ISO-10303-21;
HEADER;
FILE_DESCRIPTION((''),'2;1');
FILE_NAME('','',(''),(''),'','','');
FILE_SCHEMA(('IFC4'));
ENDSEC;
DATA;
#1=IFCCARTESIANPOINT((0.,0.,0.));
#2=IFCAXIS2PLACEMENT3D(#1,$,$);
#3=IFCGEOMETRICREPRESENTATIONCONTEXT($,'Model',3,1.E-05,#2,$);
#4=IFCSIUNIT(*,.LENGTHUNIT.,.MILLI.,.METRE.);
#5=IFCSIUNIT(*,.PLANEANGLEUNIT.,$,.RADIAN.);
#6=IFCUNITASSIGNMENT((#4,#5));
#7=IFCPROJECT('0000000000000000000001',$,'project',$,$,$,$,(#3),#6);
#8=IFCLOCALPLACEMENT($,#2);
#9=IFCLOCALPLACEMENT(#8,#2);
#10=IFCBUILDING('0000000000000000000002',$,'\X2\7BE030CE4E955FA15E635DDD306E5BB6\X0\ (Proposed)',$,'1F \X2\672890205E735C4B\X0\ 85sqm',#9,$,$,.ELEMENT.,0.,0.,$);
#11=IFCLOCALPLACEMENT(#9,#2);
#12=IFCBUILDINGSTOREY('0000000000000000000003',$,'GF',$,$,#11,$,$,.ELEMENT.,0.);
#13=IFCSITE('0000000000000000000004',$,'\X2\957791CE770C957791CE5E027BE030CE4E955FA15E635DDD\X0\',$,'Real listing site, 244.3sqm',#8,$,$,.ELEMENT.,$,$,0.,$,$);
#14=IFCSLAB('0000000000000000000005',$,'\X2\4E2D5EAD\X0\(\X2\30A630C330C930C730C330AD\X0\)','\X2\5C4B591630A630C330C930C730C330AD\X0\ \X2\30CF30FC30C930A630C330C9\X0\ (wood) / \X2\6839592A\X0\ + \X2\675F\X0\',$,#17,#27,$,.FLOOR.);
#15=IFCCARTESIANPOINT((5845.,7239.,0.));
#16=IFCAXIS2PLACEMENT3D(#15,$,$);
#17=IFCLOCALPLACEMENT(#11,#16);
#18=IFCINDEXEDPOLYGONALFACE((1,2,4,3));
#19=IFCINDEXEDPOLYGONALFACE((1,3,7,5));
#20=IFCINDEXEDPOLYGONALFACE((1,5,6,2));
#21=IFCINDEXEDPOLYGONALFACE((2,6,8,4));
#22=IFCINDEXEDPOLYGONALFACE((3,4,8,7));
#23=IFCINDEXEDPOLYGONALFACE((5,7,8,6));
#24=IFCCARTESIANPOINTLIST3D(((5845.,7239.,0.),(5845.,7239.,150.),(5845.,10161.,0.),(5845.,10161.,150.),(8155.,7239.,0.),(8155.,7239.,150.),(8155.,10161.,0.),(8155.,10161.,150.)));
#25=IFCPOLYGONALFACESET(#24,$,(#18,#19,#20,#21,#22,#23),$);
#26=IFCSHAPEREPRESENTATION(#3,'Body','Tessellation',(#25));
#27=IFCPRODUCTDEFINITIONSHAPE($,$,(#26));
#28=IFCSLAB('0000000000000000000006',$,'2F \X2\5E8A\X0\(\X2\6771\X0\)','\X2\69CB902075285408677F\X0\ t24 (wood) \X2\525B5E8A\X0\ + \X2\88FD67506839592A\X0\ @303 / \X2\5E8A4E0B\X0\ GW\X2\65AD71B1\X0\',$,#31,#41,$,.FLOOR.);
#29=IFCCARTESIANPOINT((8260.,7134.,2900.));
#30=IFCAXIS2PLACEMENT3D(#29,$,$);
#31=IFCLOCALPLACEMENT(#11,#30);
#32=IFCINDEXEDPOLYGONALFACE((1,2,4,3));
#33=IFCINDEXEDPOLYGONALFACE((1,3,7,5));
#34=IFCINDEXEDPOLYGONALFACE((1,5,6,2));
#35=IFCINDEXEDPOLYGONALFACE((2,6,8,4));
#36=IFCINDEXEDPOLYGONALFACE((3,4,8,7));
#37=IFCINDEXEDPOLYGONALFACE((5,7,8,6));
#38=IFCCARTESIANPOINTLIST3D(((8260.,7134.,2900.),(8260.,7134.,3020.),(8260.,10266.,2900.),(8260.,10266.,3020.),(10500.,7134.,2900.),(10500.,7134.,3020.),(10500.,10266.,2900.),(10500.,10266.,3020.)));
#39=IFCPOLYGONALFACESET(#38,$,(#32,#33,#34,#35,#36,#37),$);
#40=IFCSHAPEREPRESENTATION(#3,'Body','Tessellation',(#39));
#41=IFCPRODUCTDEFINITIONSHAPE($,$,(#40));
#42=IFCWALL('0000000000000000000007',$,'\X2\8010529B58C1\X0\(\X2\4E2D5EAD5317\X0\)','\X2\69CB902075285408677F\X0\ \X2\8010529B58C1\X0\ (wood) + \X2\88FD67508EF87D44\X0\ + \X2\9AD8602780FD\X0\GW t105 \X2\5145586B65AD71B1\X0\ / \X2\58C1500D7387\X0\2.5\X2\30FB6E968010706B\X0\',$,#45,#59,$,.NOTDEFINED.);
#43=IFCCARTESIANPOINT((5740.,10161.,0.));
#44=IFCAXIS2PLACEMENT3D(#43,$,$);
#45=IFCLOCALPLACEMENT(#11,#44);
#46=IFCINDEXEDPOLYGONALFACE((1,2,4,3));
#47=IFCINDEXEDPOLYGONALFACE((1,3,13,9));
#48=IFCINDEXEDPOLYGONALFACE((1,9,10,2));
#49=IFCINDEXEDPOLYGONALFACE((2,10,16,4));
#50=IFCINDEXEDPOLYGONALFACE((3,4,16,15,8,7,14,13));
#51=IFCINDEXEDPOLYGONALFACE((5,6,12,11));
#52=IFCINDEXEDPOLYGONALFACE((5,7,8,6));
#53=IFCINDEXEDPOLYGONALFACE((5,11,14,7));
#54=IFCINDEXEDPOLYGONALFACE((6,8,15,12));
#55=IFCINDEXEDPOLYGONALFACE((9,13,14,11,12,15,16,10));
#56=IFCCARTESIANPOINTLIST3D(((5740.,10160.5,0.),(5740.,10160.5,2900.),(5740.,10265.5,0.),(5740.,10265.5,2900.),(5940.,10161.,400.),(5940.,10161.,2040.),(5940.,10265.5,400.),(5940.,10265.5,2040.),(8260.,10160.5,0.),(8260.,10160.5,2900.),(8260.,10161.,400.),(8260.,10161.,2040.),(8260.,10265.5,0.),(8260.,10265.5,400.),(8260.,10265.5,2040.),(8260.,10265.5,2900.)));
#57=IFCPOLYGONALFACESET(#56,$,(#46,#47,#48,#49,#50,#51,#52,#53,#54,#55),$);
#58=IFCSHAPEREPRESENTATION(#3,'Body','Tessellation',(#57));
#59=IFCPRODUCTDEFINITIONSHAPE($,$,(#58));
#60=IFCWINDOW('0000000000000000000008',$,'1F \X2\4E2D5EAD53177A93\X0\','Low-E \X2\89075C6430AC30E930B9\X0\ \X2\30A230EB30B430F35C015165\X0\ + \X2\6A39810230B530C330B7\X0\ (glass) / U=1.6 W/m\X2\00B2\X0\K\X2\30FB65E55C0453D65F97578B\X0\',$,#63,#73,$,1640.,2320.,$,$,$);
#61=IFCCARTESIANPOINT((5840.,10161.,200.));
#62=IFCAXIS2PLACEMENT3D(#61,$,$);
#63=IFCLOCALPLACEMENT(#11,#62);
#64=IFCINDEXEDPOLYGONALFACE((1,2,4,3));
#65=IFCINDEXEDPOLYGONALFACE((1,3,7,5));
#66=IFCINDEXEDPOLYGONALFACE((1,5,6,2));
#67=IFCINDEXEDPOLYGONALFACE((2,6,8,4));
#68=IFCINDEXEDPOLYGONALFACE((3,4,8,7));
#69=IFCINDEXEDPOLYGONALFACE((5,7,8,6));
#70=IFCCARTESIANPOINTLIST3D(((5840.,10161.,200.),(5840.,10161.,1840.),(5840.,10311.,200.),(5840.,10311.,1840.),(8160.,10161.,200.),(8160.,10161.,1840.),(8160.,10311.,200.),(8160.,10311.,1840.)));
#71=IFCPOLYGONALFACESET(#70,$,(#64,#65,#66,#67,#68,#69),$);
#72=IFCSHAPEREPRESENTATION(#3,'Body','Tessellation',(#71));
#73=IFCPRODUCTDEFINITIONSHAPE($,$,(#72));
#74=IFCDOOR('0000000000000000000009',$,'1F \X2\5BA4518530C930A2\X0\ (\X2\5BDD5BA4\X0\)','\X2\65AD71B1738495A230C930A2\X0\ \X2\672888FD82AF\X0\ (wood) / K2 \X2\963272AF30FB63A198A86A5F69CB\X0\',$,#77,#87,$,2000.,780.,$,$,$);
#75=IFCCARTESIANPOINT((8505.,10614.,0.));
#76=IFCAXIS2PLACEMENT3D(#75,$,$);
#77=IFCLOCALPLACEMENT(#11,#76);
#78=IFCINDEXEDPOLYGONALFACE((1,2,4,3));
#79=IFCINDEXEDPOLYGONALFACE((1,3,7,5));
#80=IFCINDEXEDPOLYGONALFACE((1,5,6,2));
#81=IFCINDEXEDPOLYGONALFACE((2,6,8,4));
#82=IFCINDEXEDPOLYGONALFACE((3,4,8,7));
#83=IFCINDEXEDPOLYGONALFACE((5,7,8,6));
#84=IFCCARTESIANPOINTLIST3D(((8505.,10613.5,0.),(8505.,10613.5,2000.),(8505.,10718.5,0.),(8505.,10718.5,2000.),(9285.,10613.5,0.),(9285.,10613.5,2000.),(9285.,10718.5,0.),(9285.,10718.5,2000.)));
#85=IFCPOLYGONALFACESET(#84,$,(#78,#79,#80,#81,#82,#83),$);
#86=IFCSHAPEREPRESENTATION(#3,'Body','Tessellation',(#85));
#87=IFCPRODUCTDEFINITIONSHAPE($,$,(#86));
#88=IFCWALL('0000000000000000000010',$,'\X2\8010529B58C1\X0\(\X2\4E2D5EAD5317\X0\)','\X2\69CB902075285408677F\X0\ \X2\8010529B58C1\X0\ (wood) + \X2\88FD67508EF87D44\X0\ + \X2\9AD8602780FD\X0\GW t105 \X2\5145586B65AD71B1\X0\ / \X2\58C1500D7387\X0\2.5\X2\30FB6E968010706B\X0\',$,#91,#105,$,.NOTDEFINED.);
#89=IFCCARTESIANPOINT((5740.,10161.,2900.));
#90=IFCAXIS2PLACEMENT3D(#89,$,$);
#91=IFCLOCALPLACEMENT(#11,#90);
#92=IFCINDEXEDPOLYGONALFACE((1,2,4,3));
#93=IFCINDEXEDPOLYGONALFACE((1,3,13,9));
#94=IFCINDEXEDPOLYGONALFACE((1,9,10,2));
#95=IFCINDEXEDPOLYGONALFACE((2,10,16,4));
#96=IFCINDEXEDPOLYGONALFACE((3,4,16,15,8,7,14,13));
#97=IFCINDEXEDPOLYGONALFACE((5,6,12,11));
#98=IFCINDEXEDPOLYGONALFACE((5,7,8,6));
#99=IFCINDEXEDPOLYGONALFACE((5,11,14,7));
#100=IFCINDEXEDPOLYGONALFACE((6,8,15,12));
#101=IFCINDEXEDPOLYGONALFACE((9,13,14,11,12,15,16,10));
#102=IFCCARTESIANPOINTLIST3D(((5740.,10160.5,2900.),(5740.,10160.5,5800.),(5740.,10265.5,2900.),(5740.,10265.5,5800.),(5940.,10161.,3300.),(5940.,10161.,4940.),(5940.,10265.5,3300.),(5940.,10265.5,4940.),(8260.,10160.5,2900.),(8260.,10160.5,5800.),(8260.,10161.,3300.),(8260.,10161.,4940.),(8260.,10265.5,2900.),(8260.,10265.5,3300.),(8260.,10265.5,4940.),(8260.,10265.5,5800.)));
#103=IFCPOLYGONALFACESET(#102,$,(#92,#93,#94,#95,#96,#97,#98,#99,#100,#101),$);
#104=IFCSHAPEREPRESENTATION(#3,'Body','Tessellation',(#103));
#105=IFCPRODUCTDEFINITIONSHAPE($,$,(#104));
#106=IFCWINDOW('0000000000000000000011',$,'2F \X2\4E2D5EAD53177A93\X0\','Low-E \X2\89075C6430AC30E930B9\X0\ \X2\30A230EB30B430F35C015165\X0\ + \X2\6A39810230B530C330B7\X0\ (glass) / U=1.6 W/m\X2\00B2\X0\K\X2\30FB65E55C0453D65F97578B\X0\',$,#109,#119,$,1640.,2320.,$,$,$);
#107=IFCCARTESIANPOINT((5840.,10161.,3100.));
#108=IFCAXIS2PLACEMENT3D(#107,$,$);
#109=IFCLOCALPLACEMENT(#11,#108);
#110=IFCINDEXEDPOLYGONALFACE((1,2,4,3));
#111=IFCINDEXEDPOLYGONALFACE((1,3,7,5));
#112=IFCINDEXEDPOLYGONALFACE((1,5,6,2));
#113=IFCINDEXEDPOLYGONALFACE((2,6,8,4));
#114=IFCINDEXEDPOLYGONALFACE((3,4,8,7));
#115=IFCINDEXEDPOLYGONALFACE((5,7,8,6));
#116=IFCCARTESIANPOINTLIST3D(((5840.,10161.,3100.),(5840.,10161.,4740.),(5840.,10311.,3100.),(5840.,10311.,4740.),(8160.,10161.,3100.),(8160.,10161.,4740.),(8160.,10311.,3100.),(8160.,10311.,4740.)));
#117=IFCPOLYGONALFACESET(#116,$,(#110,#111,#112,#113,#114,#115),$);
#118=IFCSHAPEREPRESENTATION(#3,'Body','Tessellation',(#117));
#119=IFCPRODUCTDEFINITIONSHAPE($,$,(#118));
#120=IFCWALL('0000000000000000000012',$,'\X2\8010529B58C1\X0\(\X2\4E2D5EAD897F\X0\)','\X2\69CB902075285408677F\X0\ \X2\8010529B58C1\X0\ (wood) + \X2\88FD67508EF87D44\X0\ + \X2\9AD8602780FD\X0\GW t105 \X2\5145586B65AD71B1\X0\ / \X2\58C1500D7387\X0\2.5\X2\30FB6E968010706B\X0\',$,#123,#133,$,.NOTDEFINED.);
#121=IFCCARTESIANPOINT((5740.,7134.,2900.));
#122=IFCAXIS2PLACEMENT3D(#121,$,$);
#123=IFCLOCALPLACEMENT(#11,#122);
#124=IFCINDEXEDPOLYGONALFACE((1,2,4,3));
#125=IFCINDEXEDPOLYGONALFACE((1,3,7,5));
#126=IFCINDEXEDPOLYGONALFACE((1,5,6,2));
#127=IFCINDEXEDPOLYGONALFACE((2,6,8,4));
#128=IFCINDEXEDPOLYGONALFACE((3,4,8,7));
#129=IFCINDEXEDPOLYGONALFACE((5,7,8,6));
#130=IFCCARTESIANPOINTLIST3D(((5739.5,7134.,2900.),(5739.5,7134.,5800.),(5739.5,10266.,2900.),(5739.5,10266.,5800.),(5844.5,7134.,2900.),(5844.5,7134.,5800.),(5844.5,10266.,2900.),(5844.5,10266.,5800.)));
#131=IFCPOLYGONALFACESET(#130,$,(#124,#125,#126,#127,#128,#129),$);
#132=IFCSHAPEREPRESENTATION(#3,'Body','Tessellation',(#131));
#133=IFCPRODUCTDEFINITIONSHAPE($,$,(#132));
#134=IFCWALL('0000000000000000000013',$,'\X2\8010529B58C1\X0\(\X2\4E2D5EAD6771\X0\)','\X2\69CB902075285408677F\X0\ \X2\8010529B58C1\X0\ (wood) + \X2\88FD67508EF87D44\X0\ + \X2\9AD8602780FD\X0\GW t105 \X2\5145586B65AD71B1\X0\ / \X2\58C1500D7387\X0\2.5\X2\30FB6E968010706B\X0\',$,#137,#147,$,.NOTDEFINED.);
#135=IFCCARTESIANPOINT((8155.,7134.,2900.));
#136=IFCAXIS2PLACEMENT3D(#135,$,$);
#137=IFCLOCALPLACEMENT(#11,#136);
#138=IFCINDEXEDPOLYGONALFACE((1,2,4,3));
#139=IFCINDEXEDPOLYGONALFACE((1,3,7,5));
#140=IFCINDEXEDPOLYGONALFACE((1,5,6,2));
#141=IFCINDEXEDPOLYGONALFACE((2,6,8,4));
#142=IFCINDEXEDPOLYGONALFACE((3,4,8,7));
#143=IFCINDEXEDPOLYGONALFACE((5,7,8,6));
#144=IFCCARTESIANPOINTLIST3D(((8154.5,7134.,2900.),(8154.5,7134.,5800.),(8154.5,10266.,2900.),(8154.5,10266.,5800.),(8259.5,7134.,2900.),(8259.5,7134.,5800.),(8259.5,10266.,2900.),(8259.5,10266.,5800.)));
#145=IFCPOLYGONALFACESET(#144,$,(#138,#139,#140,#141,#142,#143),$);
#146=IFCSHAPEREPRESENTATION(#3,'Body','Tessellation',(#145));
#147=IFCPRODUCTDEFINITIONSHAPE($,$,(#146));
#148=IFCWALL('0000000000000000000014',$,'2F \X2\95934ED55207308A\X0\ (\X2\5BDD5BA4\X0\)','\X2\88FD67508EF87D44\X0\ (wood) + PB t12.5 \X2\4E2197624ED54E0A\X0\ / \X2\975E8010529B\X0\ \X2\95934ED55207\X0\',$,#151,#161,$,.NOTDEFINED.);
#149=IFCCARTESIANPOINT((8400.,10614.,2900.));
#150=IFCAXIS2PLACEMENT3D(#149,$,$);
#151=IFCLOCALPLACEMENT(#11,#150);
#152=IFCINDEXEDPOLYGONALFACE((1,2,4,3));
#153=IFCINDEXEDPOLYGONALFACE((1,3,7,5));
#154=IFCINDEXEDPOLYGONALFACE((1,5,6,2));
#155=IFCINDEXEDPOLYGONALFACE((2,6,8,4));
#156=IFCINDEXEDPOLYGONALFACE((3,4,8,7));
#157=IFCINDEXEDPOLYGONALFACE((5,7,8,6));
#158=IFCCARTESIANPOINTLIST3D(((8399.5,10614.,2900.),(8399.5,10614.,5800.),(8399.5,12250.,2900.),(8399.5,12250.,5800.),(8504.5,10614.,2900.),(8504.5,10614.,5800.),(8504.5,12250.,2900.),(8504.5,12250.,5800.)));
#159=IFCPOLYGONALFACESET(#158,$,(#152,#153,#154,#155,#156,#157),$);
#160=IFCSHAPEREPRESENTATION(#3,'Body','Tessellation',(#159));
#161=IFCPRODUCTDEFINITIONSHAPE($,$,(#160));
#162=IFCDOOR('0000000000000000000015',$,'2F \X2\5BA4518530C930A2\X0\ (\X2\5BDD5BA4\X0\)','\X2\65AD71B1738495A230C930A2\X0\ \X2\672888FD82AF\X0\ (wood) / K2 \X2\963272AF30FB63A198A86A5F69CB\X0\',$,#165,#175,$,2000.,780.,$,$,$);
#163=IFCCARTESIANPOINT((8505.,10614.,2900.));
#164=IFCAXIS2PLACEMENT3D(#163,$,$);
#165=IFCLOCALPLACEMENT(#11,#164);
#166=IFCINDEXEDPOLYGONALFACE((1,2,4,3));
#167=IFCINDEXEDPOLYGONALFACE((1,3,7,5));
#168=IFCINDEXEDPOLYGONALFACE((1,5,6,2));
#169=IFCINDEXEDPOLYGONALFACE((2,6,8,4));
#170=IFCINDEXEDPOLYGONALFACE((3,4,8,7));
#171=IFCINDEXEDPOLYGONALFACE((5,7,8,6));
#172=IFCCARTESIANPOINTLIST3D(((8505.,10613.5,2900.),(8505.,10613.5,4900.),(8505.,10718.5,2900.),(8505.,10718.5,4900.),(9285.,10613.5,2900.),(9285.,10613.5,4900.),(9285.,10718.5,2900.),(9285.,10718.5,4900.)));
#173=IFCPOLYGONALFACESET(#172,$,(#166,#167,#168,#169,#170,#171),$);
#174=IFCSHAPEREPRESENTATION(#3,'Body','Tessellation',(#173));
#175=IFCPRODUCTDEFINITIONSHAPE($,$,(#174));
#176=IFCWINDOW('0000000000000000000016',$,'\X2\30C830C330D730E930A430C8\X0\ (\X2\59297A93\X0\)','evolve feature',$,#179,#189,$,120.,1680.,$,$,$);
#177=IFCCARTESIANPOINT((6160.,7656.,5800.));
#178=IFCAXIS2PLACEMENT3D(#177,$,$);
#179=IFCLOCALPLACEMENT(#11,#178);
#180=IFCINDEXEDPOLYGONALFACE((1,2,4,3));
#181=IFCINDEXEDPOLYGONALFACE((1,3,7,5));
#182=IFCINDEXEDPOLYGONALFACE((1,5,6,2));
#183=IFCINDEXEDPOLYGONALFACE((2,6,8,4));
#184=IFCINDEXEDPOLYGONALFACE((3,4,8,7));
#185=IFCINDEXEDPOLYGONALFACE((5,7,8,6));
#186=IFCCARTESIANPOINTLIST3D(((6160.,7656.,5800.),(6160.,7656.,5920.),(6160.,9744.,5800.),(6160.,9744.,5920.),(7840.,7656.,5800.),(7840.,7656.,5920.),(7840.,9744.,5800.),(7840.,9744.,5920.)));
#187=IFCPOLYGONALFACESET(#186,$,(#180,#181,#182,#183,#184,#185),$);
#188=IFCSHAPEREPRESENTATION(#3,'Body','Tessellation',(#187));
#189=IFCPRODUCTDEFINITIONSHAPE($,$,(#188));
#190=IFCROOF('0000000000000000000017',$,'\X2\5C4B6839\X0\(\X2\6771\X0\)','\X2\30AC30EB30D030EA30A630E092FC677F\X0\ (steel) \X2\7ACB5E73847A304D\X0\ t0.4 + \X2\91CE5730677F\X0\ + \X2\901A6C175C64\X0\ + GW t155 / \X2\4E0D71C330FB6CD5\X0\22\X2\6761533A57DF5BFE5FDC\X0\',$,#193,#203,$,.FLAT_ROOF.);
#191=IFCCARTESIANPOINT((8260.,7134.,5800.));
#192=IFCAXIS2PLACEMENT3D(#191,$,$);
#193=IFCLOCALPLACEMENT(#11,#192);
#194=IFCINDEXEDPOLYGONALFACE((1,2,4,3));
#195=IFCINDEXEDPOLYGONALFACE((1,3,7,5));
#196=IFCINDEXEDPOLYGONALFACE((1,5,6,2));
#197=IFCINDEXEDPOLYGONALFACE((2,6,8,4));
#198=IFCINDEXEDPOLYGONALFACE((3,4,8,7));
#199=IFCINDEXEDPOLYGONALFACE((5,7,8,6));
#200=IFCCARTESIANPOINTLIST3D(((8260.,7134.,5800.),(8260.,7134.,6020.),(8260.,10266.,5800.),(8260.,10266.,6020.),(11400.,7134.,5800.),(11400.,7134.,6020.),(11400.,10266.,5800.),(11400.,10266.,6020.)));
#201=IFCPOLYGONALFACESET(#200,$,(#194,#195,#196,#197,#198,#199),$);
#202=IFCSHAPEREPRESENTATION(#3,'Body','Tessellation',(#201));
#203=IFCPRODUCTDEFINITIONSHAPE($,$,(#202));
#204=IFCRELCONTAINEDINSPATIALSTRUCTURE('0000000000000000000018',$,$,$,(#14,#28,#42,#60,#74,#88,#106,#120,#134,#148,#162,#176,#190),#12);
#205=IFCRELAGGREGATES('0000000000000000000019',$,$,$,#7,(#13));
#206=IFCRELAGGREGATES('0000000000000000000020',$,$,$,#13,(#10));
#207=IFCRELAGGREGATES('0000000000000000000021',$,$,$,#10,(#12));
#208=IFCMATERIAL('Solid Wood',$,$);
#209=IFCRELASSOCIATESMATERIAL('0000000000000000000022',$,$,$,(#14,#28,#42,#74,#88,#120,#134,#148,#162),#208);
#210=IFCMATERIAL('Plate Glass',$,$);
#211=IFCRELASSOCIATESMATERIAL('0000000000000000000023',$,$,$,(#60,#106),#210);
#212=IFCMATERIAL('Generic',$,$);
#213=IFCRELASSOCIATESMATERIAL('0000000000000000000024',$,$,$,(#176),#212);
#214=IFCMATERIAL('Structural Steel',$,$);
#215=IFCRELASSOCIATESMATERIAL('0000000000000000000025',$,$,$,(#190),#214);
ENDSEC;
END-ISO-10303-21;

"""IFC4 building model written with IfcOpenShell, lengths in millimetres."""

from ifc_helpers import new_model, si_unit, frame, frame_2d, origin, place, context, project, spatial, rectangle, extrude, material, element, fill, save


model = new_model("IFC4")

# Units and contexts
model_context = context("Model", 3, precision=1e-05, world=origin())
ifc_project = project(units=[si_unit("LENGTHUNIT", "METRE", prefix="MILLI"), si_unit("PLANEANGLEUNIT", "RADIAN")], contexts=[model_context])

# Site, building, storey
site_placement = place(None, origin())
site = spatial("IfcSite", under=ifc_project, at=site_placement, Name="長野県長野市篠ノ井御幣川", ObjectType="Real listing site, 244.3sqm", CompositionType="ELEMENT", RefElevation=0.0)
building_placement = place(site_placement, origin())
building = spatial("IfcBuilding", under=site, at=building_placement, Name="篠ノ井御幣川の家 (Proposed)", ObjectType="1F 木造平屋 85sqm", CompositionType="ELEMENT", ElevationOfRefHeight=0.0, ElevationOfTerrain=0.0)
storey_placement = place(building_placement, origin())
storey = spatial("IfcBuildingStorey", under=building, at=storey_placement, Name="GF", CompositionType="ELEMENT", Elevation=0.0)

# Slabs
ifc_material_1 = material(Name="Solid Wood")
slab_1_placement = place(storey_placement, frame((5845.0, 7239.0, 0.0)))
element("IfcSlab", 1, at=slab_1_placement, inside=storey, material=ifc_material_1, Name="中庭(ウッドデッキ)", Description="屋外ウッドデッキ ハードウッド (wood) / 根太 + 束", PredefinedType="FLOOR", context=model_context, shape_type="SweptSolid", body=[
    extrude(rectangle(XDim=2310.0, YDim=2922.0, at=frame_2d((1155.0, 1461.0))), frame((5845.0, 7239.0, 0.0)), (0.0, 0.0, 1.0), 150.0),
])
slab_2_placement = place(storey_placement, frame((8260.0, 7134.0, 2900.0)))
element("IfcSlab", 2, at=slab_2_placement, inside=storey, material=ifc_material_1, Name="2F 床(東)", Description="構造用合板 t24 (wood) 剛床 + 製材根太 @303 / 床下 GW断熱", PredefinedType="FLOOR", context=model_context, shape_type="SweptSolid", body=[
    extrude(rectangle(XDim=2240.0, YDim=3132.0, at=frame_2d((1120.0, 1566.0))), frame((8260.0, 7134.0, 2900.0)), (0.0, 0.0, 1.0), 120.0),
])

# Wall, opening, window
wall_1_placement = place(storey_placement, frame((5740.0, 10161.0, 0.0)))
wall_1 = element("IfcWall", 3, at=wall_1_placement, inside=storey, material=ifc_material_1, Name="耐力壁(中庭北)", Description="構造用合板 耐力壁 (wood) + 製材軸組 + 高性能GW t105 充填断熱 / 壁倍率2.5・準耐火", PredefinedType="NOTDEFINED", context=model_context, shape_type="SweptSolid", body=[
    extrude(rectangle(XDim=2520.0, YDim=105.0, at=frame_2d((1260.0, 52.0))), frame((5740.0, 10161.0, 0.0)), (0.0, 0.0, 1.0), 2900.0),
])
opening_1_placement = place(storey_placement, frame((5840.0, 10161.0, 200.0)))
opening_1 = element("IfcOpeningElement", 4, at=opening_1_placement, cuts=wall_1, PredefinedType="NOTDEFINED", context=model_context, shape_type="SweptSolid", body=[
    extrude(rectangle(XDim=2320.0, YDim=150.0, at=frame_2d((1160.0, 75.0))), frame((5840.0, 10161.0, 200.0)), (0.0, 0.0, 1.0), 1640.0),
])
ifc_material_2 = material(Name="Plate Glass")
window_1_placement = place(storey_placement, frame((5840.0, 10161.0, 200.0)))
window_1 = element("IfcWindow", 5, at=window_1_placement, inside=storey, material=ifc_material_2, Name="1F 中庭北窓", Description="Low-E 複層ガラス アルゴン封入 + 樹脂サッシ (glass) / U=1.6 W/m²K・日射取得型", OverallHeight=1640.0, OverallWidth=2320.0, context=model_context, shape_type="SweptSolid", body=[
    extrude(rectangle(XDim=2320.0, YDim=150.0, at=frame_2d((1160.0, 75.0))), frame((5840.0, 10161.0, 200.0)), (0.0, 0.0, 1.0), 1640.0),
])
fill(opening_1, window_1)

# Door
door_1_placement = place(storey_placement, frame((8505.0, 10614.0, 0.0)))
element("IfcDoor", 6, at=door_1_placement, inside=storey, material=ifc_material_1, Name="1F 室内ドア (寝室)", Description="断熱玄関ドア 木製芯 (wood) / K2 防犯・採風機構", OverallHeight=2000.0, OverallWidth=780.0, context=model_context, shape_type="SweptSolid", body=[
    extrude(rectangle(XDim=780.0, YDim=105.0, at=frame_2d((390.0, 52.0))), frame((8505.0, 10614.0, 0.0)), (0.0, 0.0, 1.0), 2000.0),
])

# Wall, opening, window
wall_2_placement = place(storey_placement, frame((5740.0, 10161.0, 2900.0)))
wall_2 = element("IfcWall", 7, at=wall_2_placement, inside=storey, material=ifc_material_1, Name="耐力壁(中庭北)", Description="構造用合板 耐力壁 (wood) + 製材軸組 + 高性能GW t105 充填断熱 / 壁倍率2.5・準耐火", PredefinedType="NOTDEFINED", context=model_context, shape_type="SweptSolid", body=[
    extrude(rectangle(XDim=2520.0, YDim=105.0, at=frame_2d((1260.0, 52.0))), frame((5740.0, 10161.0, 2900.0)), (0.0, 0.0, 1.0), 2900.0),
])
opening_2_placement = place(storey_placement, frame((5840.0, 10161.0, 3100.0)))
opening_2 = element("IfcOpeningElement", 8, at=opening_2_placement, cuts=wall_2, PredefinedType="NOTDEFINED", context=model_context, shape_type="SweptSolid", body=[
    extrude(rectangle(XDim=2320.0, YDim=150.0, at=frame_2d((1160.0, 75.0))), frame((5840.0, 10161.0, 3100.0)), (0.0, 0.0, 1.0), 1640.0),
])
window_2_placement = place(storey_placement, frame((5840.0, 10161.0, 3100.0)))
window_2 = element("IfcWindow", 9, at=window_2_placement, inside=storey, material=ifc_material_2, Name="2F 中庭北窓", Description="Low-E 複層ガラス アルゴン封入 + 樹脂サッシ (glass) / U=1.6 W/m²K・日射取得型", OverallHeight=1640.0, OverallWidth=2320.0, context=model_context, shape_type="SweptSolid", body=[
    extrude(rectangle(XDim=2320.0, YDim=150.0, at=frame_2d((1160.0, 75.0))), frame((5840.0, 10161.0, 3100.0)), (0.0, 0.0, 1.0), 1640.0),
])
fill(opening_2, window_2)

# Walls
wall_3_placement = place(storey_placement, frame((5740.0, 7134.0, 2900.0)))
element("IfcWall", 10, at=wall_3_placement, inside=storey, material=ifc_material_1, Name="耐力壁(中庭西)", Description="構造用合板 耐力壁 (wood) + 製材軸組 + 高性能GW t105 充填断熱 / 壁倍率2.5・準耐火", PredefinedType="NOTDEFINED", context=model_context, shape_type="SweptSolid", body=[
    extrude(rectangle(XDim=105.0, YDim=3132.0, at=frame_2d((52.0, 1566.0))), frame((5740.0, 7134.0, 2900.0)), (0.0, 0.0, 1.0), 2900.0),
])
wall_4_placement = place(storey_placement, frame((8155.0, 7134.0, 2900.0)))
element("IfcWall", 11, at=wall_4_placement, inside=storey, material=ifc_material_1, Name="耐力壁(中庭東)", Description="構造用合板 耐力壁 (wood) + 製材軸組 + 高性能GW t105 充填断熱 / 壁倍率2.5・準耐火", PredefinedType="NOTDEFINED", context=model_context, shape_type="SweptSolid", body=[
    extrude(rectangle(XDim=105.0, YDim=3132.0, at=frame_2d((52.0, 1566.0))), frame((8155.0, 7134.0, 2900.0)), (0.0, 0.0, 1.0), 2900.0),
])
wall_5_placement = place(storey_placement, frame((8400.0, 10614.0, 2900.0)))
element("IfcWall", 12, at=wall_5_placement, inside=storey, material=ifc_material_1, Name="2F 間仕切り (寝室)", Description="製材軸組 (wood) + PB t12.5 両面仕上 / 非耐力 間仕切", PredefinedType="NOTDEFINED", context=model_context, shape_type="SweptSolid", body=[
    extrude(rectangle(XDim=105.0, YDim=1636.0, at=frame_2d((52.0, 818.0))), frame((8400.0, 10614.0, 2900.0)), (0.0, 0.0, 1.0), 2900.0),
])

# Door
door_2_placement = place(storey_placement, frame((8505.0, 10614.0, 2900.0)))
element("IfcDoor", 13, at=door_2_placement, inside=storey, material=ifc_material_1, Name="2F 室内ドア (寝室)", Description="断熱玄関ドア 木製芯 (wood) / K2 防犯・採風機構", OverallHeight=2000.0, OverallWidth=780.0, context=model_context, shape_type="SweptSolid", body=[
    extrude(rectangle(XDim=780.0, YDim=105.0, at=frame_2d((390.0, 52.0))), frame((8505.0, 10614.0, 2900.0)), (0.0, 0.0, 1.0), 2000.0),
])

# Window
ifc_material_3 = material(Name="Generic")
window_3_placement = place(storey_placement, frame((6160.0, 7656.0, 5800.0)))
element("IfcWindow", 14, at=window_3_placement, inside=storey, material=ifc_material_3, Name="トップライト (天窓)", Description="evolve feature", OverallHeight=120.0, OverallWidth=1680.0, context=model_context, shape_type="SweptSolid", body=[
    extrude(rectangle(XDim=1680.0, YDim=2088.0, at=frame_2d((840.0, 1044.0))), frame((6160.0, 7656.0, 5800.0)), (0.0, 0.0, 1.0), 120.0),
])

# Roof
ifc_material_4 = material(Name="Structural Steel")
roof_placement = place(storey_placement, frame((8260.0, 7134.0, 5800.0)))
element("IfcRoof", 15, at=roof_placement, inside=storey, material=ifc_material_4, Name="屋根(東)", Description="ガルバリウム鋼板 (steel) 立平葺き t0.4 + 野地板 + 通気層 + GW t155 / 不燃・法22条区域対応", PredefinedType="FLAT_ROOF", context=model_context, shape_type="SweptSolid", body=[
    extrude(rectangle(XDim=3140.0, YDim=3132.0, at=frame_2d((1570.0, 1566.0))), frame((8260.0, 7134.0, 5800.0)), (0.0, 0.0, 1.0), 220.0),
])

save(model, "model.ifc")
